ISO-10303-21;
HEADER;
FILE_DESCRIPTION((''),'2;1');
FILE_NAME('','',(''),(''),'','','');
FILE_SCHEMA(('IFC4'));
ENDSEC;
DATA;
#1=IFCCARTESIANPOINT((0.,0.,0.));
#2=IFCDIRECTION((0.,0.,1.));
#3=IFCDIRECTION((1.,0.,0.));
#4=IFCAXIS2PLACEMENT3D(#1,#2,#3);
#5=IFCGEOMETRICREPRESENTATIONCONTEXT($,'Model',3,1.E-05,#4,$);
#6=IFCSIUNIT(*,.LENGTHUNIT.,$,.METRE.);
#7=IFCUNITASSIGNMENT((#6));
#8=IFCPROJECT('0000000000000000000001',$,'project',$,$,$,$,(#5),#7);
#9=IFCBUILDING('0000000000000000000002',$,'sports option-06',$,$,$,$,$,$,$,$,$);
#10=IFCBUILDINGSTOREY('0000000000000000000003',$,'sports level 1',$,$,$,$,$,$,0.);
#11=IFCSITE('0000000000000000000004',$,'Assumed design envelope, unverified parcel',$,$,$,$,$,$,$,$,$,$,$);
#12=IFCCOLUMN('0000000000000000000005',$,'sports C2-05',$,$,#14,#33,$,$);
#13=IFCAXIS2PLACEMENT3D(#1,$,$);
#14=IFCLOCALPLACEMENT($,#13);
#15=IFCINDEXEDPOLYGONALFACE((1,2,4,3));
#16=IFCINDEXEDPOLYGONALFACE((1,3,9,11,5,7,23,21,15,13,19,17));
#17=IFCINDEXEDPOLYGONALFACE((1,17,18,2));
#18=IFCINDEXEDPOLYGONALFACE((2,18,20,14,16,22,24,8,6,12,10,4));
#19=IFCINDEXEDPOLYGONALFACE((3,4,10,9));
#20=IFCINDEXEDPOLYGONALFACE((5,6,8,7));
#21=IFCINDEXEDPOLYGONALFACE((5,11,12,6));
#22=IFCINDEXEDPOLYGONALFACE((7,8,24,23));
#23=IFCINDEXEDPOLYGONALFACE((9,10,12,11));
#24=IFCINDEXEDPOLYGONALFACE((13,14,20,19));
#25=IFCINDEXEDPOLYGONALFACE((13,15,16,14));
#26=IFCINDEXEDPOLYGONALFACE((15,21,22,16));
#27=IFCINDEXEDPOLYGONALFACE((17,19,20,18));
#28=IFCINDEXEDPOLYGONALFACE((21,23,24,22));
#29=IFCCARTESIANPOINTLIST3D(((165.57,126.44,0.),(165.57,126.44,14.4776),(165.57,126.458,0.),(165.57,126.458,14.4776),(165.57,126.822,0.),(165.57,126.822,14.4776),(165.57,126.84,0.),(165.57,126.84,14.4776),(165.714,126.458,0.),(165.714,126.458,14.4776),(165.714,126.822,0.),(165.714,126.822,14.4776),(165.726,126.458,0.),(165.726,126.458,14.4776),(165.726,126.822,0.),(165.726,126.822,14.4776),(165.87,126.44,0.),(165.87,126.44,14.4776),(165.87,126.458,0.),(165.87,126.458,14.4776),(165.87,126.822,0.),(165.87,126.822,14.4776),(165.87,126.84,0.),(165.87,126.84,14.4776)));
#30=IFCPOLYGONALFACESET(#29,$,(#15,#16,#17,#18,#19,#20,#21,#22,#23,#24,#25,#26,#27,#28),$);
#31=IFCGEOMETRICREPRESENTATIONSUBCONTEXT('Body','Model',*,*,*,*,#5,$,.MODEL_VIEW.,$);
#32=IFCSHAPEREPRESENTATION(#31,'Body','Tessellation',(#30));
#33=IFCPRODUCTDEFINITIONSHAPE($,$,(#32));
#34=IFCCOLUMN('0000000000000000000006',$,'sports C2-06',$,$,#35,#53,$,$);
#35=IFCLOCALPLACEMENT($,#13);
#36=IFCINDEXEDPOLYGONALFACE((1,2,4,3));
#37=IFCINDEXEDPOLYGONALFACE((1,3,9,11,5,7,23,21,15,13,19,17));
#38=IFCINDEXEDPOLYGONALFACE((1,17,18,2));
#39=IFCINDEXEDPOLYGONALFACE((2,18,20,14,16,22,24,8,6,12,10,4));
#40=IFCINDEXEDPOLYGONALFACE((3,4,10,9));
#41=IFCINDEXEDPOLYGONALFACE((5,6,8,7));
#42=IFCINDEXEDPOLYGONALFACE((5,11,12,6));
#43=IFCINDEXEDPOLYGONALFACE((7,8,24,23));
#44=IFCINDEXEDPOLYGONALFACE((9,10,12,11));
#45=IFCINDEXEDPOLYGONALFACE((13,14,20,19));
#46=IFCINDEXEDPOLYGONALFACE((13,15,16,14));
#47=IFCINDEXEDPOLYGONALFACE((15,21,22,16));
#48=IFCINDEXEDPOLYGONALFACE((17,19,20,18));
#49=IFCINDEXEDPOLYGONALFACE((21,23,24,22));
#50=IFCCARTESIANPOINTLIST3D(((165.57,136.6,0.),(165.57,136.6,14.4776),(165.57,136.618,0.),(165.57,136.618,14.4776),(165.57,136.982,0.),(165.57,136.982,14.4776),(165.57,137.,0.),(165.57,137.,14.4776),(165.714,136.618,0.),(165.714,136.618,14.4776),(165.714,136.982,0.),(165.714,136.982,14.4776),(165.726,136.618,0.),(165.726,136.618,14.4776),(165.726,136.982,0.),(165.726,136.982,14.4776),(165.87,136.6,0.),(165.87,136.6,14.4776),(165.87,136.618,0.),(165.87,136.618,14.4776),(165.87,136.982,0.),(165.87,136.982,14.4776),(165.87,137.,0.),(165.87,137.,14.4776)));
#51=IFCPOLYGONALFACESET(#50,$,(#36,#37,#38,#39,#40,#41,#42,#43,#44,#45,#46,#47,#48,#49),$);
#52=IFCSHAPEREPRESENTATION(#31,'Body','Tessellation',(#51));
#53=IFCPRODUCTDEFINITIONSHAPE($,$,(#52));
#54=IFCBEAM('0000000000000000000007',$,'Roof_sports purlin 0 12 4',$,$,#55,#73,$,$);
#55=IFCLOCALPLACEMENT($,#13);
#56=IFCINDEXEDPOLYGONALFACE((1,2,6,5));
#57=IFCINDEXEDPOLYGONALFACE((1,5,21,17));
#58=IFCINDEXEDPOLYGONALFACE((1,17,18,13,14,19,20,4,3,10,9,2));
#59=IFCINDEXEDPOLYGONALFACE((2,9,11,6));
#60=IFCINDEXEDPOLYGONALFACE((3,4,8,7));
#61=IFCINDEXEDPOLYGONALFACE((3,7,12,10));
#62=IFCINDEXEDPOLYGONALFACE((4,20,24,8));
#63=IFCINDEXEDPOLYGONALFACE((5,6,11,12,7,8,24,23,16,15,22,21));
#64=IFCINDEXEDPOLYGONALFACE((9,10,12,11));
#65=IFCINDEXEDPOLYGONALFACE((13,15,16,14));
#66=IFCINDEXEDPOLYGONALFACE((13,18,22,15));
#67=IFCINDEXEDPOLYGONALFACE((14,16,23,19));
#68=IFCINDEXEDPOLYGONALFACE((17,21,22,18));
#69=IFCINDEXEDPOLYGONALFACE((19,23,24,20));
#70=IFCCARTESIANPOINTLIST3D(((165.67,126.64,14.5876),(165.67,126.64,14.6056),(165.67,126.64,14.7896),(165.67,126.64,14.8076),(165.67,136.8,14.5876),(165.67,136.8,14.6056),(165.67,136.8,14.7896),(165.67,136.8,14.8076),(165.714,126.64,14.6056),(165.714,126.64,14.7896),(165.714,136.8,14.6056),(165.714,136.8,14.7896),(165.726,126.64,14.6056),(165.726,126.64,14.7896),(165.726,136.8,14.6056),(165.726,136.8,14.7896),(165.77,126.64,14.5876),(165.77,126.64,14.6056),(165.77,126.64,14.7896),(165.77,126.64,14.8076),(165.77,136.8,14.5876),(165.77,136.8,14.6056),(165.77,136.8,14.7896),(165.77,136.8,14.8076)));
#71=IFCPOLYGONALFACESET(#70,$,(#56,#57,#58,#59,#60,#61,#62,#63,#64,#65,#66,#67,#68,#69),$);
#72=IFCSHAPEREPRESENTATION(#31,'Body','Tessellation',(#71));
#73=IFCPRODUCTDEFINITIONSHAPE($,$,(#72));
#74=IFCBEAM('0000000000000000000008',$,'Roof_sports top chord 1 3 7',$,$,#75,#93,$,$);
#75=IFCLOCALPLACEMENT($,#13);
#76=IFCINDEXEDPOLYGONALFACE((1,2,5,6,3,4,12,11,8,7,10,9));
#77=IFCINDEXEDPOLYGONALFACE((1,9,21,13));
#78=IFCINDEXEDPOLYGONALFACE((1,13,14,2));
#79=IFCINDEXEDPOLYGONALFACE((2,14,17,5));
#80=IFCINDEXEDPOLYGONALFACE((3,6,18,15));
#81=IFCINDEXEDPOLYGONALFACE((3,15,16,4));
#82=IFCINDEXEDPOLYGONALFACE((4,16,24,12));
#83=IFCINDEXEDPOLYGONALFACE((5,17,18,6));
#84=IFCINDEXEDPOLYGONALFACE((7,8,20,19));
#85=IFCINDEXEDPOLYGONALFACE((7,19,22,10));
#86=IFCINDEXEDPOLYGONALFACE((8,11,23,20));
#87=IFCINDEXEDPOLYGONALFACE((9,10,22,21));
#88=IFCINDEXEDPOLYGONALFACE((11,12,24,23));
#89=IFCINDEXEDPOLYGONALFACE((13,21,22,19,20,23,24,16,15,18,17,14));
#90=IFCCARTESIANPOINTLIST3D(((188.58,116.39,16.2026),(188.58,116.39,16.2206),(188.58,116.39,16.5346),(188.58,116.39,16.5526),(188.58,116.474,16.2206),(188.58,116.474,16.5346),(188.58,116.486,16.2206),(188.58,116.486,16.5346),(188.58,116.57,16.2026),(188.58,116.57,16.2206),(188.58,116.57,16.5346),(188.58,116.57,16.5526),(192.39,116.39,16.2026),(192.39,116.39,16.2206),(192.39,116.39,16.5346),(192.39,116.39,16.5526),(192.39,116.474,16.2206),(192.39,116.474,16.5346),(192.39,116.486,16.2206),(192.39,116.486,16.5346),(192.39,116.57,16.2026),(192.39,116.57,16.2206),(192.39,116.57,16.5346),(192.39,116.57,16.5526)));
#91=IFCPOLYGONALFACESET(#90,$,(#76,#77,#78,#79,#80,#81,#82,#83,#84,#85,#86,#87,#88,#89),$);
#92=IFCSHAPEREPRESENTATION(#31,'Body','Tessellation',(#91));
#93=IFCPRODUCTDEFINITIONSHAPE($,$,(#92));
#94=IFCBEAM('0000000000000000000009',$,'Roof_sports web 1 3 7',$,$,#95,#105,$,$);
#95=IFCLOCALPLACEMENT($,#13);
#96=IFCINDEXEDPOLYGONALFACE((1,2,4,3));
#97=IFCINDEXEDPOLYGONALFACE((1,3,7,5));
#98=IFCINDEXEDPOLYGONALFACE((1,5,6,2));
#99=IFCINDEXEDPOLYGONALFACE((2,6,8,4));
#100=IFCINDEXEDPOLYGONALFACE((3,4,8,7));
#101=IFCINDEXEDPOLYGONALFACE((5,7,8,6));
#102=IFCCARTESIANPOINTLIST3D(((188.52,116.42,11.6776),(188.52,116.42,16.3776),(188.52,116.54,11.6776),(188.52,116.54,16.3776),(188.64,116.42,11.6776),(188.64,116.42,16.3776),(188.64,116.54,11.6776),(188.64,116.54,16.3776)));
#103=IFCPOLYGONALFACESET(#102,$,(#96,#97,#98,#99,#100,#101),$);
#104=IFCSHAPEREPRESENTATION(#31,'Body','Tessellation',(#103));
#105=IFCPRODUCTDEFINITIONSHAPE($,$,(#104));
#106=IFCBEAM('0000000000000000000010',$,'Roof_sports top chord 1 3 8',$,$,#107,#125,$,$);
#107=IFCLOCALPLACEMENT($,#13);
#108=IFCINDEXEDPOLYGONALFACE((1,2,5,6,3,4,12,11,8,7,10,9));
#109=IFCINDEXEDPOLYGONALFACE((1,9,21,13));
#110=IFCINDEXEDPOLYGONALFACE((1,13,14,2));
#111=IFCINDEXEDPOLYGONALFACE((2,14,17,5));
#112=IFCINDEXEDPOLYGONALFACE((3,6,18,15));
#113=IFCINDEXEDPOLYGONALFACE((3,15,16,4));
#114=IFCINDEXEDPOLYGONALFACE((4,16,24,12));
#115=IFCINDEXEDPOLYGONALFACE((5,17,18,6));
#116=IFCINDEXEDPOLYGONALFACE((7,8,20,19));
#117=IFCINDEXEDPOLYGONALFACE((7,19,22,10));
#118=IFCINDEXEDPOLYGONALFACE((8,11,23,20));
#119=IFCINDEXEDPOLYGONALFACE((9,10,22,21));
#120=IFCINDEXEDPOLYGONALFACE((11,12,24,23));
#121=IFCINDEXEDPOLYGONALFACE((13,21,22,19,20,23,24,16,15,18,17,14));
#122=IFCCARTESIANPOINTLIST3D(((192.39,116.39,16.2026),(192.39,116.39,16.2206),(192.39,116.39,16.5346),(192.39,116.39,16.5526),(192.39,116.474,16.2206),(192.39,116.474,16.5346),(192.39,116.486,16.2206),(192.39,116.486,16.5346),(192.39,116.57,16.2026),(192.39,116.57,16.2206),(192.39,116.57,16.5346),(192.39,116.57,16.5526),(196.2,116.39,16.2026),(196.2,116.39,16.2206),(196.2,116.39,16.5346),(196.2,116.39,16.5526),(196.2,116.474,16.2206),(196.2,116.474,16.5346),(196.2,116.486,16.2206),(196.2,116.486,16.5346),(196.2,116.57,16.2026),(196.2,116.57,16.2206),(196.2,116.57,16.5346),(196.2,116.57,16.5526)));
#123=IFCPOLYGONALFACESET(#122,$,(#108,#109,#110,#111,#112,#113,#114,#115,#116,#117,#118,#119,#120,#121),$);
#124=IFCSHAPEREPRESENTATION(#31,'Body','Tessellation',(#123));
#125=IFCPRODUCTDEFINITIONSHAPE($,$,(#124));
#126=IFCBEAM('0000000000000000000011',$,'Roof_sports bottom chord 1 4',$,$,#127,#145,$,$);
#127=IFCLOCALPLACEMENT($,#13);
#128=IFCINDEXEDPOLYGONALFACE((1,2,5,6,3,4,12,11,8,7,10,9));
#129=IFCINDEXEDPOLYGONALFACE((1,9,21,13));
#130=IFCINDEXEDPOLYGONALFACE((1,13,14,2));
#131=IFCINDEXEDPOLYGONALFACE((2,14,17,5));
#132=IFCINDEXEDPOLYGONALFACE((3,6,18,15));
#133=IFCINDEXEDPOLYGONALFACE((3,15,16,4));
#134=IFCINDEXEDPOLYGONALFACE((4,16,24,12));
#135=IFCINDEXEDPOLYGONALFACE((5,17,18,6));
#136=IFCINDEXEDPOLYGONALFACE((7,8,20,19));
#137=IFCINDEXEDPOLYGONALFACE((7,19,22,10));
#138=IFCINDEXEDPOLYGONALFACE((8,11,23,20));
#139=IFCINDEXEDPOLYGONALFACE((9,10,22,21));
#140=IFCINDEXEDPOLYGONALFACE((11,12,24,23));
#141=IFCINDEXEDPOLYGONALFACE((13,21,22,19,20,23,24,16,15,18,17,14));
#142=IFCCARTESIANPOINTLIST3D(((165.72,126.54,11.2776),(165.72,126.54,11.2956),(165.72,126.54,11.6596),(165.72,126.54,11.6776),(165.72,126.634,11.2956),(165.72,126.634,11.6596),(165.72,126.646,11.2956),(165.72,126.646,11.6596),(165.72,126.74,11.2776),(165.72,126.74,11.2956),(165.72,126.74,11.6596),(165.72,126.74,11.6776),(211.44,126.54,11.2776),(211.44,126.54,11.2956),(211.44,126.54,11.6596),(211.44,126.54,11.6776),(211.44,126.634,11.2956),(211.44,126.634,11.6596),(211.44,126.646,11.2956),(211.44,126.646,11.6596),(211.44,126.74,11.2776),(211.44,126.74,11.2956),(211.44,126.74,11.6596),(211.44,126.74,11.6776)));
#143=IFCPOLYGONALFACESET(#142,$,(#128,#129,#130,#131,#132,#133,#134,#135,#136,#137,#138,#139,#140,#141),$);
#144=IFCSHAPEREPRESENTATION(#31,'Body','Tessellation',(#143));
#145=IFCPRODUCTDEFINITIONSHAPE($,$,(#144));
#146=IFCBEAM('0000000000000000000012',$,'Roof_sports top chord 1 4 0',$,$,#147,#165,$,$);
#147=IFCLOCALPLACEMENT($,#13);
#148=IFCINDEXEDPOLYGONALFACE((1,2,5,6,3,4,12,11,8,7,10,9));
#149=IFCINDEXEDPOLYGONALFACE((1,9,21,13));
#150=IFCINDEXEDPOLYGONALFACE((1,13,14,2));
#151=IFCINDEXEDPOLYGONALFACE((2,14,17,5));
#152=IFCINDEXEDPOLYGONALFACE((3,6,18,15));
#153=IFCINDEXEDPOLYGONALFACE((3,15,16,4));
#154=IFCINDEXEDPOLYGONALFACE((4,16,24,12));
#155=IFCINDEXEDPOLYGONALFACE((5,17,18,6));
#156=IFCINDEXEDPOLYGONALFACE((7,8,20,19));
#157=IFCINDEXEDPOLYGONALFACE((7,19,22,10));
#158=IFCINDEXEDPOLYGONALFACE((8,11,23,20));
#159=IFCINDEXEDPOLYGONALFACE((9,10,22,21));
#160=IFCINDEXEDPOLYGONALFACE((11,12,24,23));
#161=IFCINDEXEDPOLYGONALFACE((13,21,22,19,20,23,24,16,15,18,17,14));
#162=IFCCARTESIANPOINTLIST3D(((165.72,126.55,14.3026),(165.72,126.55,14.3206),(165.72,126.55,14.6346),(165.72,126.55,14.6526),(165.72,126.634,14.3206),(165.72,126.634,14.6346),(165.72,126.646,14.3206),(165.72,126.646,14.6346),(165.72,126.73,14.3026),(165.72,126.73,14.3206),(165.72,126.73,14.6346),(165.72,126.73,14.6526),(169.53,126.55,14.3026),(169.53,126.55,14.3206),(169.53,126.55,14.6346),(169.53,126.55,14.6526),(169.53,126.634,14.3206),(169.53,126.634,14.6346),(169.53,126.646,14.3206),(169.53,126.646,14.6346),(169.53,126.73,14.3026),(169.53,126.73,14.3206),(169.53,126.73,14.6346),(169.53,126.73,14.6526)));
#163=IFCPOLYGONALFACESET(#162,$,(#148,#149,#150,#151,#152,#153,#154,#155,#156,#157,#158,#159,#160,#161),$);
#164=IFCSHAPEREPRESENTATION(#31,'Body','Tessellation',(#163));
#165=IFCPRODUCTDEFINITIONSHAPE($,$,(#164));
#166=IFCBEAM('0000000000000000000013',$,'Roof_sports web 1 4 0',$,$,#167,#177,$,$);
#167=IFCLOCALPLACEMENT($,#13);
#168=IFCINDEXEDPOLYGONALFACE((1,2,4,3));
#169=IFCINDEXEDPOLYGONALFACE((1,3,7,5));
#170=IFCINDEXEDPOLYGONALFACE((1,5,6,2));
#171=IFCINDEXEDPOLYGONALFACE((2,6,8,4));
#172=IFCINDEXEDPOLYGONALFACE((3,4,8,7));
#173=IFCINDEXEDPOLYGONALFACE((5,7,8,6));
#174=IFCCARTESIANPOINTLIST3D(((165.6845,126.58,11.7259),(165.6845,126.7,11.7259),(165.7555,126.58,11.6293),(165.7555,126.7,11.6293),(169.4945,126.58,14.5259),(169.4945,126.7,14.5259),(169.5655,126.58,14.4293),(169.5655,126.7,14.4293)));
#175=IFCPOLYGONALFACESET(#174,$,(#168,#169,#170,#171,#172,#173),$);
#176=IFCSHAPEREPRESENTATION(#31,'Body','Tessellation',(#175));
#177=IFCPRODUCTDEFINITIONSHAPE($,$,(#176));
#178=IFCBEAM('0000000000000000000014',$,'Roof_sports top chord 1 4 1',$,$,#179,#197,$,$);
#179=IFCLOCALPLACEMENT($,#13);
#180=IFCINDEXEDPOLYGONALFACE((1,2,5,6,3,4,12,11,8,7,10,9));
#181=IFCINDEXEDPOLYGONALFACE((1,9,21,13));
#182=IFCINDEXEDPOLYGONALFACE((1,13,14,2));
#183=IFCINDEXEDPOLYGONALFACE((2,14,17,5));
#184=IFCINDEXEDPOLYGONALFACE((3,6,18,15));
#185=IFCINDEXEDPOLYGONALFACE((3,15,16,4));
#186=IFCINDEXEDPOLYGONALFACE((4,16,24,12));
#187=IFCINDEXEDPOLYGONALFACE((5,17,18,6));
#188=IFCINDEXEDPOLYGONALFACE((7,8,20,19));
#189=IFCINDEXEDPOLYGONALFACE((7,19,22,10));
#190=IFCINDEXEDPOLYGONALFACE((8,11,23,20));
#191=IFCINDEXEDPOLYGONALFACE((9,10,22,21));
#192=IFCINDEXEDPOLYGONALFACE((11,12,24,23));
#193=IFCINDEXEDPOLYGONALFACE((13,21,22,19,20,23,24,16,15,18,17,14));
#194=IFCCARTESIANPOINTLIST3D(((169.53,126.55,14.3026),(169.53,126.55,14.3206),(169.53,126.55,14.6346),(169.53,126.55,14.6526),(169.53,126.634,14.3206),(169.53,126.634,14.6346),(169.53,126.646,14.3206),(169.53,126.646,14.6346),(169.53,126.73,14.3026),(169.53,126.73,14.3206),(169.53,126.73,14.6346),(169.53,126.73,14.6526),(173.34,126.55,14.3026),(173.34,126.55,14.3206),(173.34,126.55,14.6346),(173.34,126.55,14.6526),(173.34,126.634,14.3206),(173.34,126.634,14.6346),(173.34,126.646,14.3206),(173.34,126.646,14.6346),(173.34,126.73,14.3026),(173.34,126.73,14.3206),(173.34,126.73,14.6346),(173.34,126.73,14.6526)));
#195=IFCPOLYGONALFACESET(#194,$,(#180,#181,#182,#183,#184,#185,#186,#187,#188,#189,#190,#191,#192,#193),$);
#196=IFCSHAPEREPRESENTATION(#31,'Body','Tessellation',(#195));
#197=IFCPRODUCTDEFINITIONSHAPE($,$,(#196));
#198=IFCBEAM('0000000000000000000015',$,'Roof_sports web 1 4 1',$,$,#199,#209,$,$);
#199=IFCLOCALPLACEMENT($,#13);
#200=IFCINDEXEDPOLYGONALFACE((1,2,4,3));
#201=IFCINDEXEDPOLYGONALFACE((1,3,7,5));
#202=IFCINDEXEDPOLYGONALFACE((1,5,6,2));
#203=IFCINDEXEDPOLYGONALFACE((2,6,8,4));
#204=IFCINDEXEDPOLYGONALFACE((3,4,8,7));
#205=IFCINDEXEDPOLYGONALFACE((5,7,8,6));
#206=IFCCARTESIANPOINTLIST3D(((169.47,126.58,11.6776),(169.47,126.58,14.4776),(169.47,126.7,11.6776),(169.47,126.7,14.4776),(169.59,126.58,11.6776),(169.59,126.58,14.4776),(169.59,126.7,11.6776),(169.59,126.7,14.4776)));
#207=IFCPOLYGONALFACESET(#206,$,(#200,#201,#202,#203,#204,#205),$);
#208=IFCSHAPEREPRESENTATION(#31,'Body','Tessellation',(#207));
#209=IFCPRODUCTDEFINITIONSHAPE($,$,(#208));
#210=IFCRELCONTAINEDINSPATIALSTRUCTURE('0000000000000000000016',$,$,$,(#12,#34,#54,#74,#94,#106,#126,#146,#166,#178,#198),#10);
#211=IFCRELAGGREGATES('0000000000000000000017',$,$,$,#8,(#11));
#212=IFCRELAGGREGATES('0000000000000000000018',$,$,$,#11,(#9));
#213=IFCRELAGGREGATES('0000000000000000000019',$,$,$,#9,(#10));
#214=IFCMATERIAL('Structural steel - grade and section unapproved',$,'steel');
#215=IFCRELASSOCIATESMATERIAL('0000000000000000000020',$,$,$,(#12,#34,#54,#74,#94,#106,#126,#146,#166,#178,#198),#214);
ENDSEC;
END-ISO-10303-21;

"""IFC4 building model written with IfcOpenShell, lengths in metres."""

from ifc_helpers import new_model, si_unit, frame, origin_with_axes, place, context, subcontext, project, spatial, rectangle, i_section, extrude, material, element, save


model = new_model("IFC4")

# Units and contexts
model_context = context("Model", 3, precision=1e-05, world=origin_with_axes())
body_context = subcontext(model_context, "Body", "Model", "MODEL_VIEW")
ifc_project = project(units=[si_unit("LENGTHUNIT", "METRE")], contexts=[model_context])

# Site, building, storey
site = spatial("IfcSite", under=ifc_project, Name="Assumed design envelope, unverified parcel")
building = spatial("IfcBuilding", under=site, Name="sports option-06")
storey = spatial("IfcBuildingStorey", under=building, Name="sports level 1", Elevation=0.0)

# Columns
ifc_material_1 = material(Name="Structural steel - grade and section unapproved", Category="steel")
for number, where, z_axis, x_axis, name in (
    (1, (165.72, 126.64, 0.0), (0.0, 0.0, 1.0), (-1.0, 0.0, 0.0), "sports C2-05"),
    (2, (165.72, 136.8, 0.0), (0.0, 0.0, 1.0), (-1.0, 0.0, 0.0), "sports C2-06"),
):
    element("IfcColumn", number, at=place(None, frame(where, z_axis=z_axis, x_axis=x_axis)), inside=storey, material=ifc_material_1, Name=name, context=body_context, shape_type="SweptSolid", body=[
        extrude(i_section(OverallWidth=0.3, OverallDepth=0.4, WebThickness=0.012, FlangeThickness=0.018, FilletRadius=0.0), origin_with_axes(), (0.0, 0.0, 1.0), 14.4776),
    ])

# Beams
beam_1_placement = place(None, frame((165.72, 126.64, 14.6976), z_axis=(0.0, 1.0, 0.0), x_axis=(-1.0, 0.0, 0.0)))
element("IfcBeam", 3, at=beam_1_placement, inside=storey, material=ifc_material_1, Name="Roof_sports purlin 0 12 4", context=body_context, shape_type="SweptSolid", body=[
    extrude(i_section(OverallWidth=0.1, OverallDepth=0.22, WebThickness=0.012, FlangeThickness=0.018, FilletRadius=0.0), origin_with_axes(), (0.0, 0.0, 1.0), 10.16),
])
beam_2_placement = place(None, frame((188.58, 116.48, 16.3776), z_axis=(1.0, 0.0, 0.0), x_axis=(0.0, 1.0, 0.0)))
element("IfcBeam", 4, at=beam_2_placement, inside=storey, material=ifc_material_1, Name="Roof_sports top chord 1 3 7", context=body_context, shape_type="SweptSolid", body=[
    extrude(i_section(OverallWidth=0.18, OverallDepth=0.35, WebThickness=0.012, FlangeThickness=0.018, FilletRadius=0.0), origin_with_axes(), (0.0, 0.0, 1.0), 3.81),
])
beam_3_placement = place(None, frame((188.58, 116.48, 11.6776), z_axis=(0.0, 0.0, 1.0), x_axis=(-1.0, 0.0, 0.0)))
element("IfcBeam", 5, at=beam_3_placement, inside=storey, material=ifc_material_1, Name="Roof_sports web 1 3 7", context=body_context, shape_type="SweptSolid", body=[
    extrude(rectangle(XDim=0.12, YDim=0.12), origin_with_axes(), (0.0, 0.0, 1.0), 4.7),
])
beam_4_placement = place(None, frame((192.39, 116.48, 16.3776), z_axis=(1.0, 0.0, 0.0), x_axis=(0.0, 1.0, 0.0)))
element("IfcBeam", 6, at=beam_4_placement, inside=storey, material=ifc_material_1, Name="Roof_sports top chord 1 3 8", context=body_context, shape_type="SweptSolid", body=[
    extrude(i_section(OverallWidth=0.18, OverallDepth=0.35, WebThickness=0.012, FlangeThickness=0.018, FilletRadius=0.0), origin_with_axes(), (0.0, 0.0, 1.0), 3.81),
])
beam_5_placement = place(None, frame((165.72, 126.64, 11.4776), z_axis=(1.0, 0.0, 0.0), x_axis=(0.0, 1.0, 0.0)))
element("IfcBeam", 7, at=beam_5_placement, inside=storey, material=ifc_material_1, Name="Roof_sports bottom chord 1 4", context=body_context, shape_type="SweptSolid", body=[
    extrude(i_section(OverallWidth=0.2, OverallDepth=0.4, WebThickness=0.012, FlangeThickness=0.018, FilletRadius=0.0), origin_with_axes(), (0.0, 0.0, 1.0), 45.72),
])
beam_6_placement = place(None, frame((165.72, 126.64, 14.4776), z_axis=(1.0, 0.0, 0.0), x_axis=(0.0, 1.0, 0.0)))
element("IfcBeam", 8, at=beam_6_placement, inside=storey, material=ifc_material_1, Name="Roof_sports top chord 1 4 0", context=body_context, shape_type="SweptSolid", body=[
    extrude(i_section(OverallWidth=0.18, OverallDepth=0.35, WebThickness=0.012, FlangeThickness=0.018, FilletRadius=0.0), origin_with_axes(), (0.0, 0.0, 1.0), 3.81),
])
beam_7_placement = place(None, frame((165.72, 126.64, 11.6776), z_axis=(0.805799, 0.0, 0.592189), x_axis=(0.0, 1.0, 0.0)))
element("IfcBeam", 9, at=beam_7_placement, inside=storey, material=ifc_material_1, Name="Roof_sports web 1 4 0", context=body_context, shape_type="SweptSolid", body=[
    extrude(rectangle(XDim=0.12, YDim=0.12), origin_with_axes(), (0.0, 0.0, 1.0), 4.7282),
])
beam_8_placement = place(None, frame((169.53, 126.64, 14.4776), z_axis=(1.0, 0.0, 0.0), x_axis=(0.0, 1.0, 0.0)))
element("IfcBeam", 10, at=beam_8_placement, inside=storey, material=ifc_material_1, Name="Roof_sports top chord 1 4 1", context=body_context, shape_type="SweptSolid", body=[
    extrude(i_section(OverallWidth=0.18, OverallDepth=0.35, WebThickness=0.012, FlangeThickness=0.018, FilletRadius=0.0), origin_with_axes(), (0.0, 0.0, 1.0), 3.81),
])
beam_9_placement = place(None, frame((169.53, 126.64, 11.6776), z_axis=(0.0, 0.0, 1.0), x_axis=(-1.0, 0.0, 0.0)))
element("IfcBeam", 11, at=beam_9_placement, inside=storey, material=ifc_material_1, Name="Roof_sports web 1 4 1", context=body_context, shape_type="SweptSolid", body=[
    extrude(rectangle(XDim=0.12, YDim=0.12), origin_with_axes(), (0.0, 0.0, 1.0), 2.8),
])

save(model, "model.ifc")
